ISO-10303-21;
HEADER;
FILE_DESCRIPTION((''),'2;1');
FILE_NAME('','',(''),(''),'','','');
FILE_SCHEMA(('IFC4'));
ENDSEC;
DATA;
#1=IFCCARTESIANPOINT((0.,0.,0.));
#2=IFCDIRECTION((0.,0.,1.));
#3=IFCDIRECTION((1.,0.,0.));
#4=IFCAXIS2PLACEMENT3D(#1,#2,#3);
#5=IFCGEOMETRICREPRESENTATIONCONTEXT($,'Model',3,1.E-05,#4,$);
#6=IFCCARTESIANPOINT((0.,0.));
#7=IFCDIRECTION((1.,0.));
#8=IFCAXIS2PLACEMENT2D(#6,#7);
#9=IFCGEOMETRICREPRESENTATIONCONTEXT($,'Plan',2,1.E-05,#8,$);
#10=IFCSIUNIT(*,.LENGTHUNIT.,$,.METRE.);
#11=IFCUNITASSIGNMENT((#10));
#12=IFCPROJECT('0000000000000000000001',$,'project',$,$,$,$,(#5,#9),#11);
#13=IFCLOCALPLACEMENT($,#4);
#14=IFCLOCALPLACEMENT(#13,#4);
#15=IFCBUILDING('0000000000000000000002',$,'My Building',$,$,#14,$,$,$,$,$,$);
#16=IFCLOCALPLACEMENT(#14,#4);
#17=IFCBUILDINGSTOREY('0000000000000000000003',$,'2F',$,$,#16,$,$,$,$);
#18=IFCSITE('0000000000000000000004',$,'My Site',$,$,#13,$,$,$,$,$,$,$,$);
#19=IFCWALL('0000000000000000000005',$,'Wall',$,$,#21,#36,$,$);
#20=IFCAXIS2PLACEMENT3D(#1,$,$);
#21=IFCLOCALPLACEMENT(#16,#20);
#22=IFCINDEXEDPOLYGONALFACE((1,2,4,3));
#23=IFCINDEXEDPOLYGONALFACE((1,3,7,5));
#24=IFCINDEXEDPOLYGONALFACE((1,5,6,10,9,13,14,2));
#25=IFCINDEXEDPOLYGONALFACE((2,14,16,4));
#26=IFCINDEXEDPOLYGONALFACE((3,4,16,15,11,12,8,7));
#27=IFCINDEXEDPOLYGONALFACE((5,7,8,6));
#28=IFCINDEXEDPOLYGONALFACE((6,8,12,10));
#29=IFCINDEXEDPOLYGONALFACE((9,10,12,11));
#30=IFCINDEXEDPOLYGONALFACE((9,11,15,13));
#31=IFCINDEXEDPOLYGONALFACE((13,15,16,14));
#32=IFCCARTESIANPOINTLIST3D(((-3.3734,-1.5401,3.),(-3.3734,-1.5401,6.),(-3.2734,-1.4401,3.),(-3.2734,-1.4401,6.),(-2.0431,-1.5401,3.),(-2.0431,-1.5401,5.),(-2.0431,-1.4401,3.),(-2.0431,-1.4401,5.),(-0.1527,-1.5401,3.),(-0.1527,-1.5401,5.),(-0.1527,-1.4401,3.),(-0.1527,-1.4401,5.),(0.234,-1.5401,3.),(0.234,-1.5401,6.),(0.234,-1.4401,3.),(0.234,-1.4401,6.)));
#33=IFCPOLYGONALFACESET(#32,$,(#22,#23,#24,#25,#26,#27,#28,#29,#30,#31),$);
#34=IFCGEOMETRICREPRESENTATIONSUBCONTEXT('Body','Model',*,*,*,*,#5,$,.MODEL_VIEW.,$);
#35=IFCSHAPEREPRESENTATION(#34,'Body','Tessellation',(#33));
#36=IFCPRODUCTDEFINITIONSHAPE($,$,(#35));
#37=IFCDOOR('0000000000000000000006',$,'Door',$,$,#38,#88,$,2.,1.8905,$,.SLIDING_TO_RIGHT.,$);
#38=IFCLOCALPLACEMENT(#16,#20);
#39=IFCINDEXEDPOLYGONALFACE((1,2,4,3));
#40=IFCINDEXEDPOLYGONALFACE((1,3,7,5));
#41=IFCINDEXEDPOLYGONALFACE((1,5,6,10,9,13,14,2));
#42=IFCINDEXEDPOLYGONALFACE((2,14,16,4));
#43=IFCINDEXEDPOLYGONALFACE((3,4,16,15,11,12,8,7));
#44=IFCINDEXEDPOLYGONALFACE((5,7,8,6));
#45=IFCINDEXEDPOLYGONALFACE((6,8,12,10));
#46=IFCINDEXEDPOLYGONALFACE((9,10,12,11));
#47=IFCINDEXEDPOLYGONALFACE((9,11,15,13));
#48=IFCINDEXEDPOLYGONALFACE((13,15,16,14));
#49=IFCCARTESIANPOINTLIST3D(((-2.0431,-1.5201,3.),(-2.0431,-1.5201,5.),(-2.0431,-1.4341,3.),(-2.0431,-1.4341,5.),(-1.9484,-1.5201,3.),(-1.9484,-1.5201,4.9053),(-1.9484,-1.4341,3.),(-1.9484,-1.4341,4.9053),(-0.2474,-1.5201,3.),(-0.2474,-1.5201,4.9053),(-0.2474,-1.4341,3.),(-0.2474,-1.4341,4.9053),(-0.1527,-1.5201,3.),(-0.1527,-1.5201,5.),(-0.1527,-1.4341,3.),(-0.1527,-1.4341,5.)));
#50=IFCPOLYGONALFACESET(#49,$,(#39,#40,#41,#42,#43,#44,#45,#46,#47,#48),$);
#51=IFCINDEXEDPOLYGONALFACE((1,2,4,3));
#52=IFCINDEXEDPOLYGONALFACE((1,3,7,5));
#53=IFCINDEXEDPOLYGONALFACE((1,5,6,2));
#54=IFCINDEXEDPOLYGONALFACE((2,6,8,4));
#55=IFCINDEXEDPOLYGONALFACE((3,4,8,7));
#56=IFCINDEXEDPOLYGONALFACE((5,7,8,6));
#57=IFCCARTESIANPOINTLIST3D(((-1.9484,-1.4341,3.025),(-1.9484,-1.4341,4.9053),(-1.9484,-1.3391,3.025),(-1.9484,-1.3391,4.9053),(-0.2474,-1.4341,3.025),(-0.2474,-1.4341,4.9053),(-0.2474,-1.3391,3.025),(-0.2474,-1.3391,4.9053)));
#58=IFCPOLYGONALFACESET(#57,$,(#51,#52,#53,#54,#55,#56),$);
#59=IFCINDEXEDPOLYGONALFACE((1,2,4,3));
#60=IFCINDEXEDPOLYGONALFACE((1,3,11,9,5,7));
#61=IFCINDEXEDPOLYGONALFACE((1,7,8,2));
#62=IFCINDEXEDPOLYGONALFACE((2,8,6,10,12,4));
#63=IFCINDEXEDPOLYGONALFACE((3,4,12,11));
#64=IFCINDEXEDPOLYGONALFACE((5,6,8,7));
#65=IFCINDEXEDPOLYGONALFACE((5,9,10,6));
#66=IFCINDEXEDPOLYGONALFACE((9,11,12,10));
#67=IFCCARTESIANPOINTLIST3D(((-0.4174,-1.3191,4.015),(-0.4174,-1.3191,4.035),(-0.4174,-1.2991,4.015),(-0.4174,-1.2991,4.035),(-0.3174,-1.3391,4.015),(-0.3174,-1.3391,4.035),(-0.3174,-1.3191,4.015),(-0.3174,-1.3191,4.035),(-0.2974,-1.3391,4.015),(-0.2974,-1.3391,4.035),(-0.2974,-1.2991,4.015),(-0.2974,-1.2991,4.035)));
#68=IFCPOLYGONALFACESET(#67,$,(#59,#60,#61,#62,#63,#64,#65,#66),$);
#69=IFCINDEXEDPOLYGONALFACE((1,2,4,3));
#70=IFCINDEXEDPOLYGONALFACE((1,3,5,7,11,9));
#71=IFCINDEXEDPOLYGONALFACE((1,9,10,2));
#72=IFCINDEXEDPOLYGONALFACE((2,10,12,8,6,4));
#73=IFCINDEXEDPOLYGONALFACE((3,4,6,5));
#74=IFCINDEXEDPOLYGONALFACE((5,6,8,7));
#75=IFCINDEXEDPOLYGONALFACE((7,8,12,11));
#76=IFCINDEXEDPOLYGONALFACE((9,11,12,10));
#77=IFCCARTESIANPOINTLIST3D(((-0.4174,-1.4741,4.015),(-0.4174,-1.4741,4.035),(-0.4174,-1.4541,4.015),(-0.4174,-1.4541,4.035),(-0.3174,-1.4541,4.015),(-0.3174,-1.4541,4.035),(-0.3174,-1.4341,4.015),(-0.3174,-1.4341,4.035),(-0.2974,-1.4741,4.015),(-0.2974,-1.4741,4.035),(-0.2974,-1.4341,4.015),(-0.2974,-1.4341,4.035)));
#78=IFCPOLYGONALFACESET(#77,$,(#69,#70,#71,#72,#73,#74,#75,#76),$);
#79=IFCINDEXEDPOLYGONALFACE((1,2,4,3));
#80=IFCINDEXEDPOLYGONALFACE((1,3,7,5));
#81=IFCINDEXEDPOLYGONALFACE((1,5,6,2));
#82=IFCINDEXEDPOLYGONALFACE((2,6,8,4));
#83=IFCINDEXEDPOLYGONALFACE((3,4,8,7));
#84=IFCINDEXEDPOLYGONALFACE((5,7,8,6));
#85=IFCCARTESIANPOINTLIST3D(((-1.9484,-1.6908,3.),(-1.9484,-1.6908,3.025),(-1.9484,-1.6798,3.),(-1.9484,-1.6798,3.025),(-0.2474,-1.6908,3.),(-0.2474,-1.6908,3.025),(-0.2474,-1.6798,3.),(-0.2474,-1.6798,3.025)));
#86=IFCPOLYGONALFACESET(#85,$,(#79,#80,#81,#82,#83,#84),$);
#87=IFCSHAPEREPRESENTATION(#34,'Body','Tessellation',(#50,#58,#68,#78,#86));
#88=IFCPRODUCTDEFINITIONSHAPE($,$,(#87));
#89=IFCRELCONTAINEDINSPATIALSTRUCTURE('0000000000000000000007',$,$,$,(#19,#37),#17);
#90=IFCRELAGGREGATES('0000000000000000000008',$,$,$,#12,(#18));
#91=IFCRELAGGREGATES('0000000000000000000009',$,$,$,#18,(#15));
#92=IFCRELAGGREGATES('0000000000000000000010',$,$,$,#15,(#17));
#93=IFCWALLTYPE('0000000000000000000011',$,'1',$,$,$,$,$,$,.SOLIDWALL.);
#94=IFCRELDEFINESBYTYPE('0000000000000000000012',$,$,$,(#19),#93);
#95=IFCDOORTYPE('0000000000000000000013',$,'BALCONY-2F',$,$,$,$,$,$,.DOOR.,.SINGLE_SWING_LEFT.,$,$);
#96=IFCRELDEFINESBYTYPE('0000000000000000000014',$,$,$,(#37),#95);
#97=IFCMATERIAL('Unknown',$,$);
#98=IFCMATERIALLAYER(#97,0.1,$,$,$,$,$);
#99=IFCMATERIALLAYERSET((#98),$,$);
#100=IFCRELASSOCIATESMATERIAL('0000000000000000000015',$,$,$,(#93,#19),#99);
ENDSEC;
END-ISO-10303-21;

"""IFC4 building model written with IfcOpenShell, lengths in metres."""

from ifc_helpers import new_model, entity, si_unit, frame, origin_with_axes, origin_2d_with_axis, place, context, subcontext, project, spatial, line, indexed_curve, outline, extrude, shape, source, transform, mapped, material, layer, layer_set, layer_usage, type_object, type_shapes, element, fill, save


model = new_model("IFC4")

# Units and contexts
model_context = context("Model", 3, precision=1e-05, world=origin_with_axes())
plan_context = context("Plan", 2, precision=1e-05, world=origin_2d_with_axis())
body_context_1 = subcontext(model_context, "Body", "Model", "MODEL_VIEW")
body_context_2 = subcontext(plan_context, "Body", "Plan", "PLAN_VIEW")
ifc_project = project(units=[si_unit("LENGTHUNIT", "METRE")], contexts=[model_context, plan_context])

# Site, building, storey
site_placement = place(None, origin_with_axes())
site = spatial("IfcSite", under=ifc_project, at=site_placement, Name="My Site")
building_placement = place(site_placement, origin_with_axes())
building = spatial("IfcBuilding", under=site, at=building_placement, Name="My Building")
storey_placement = place(building_placement, origin_with_axes())
storey = spatial("IfcBuildingStorey", under=building, at=storey_placement, Name="2F")

# Shared definitions
ifc_material = material(Name="Unknown")

# Wall, opening, door
ifc_layer_1 = layer(ifc_material, 0.1)
ifc_layer_set_1 = layer_set([ifc_layer_1])
ifc_layer_usage_1 = layer_usage(ifc_layer_set_1, "AXIS2", "POSITIVE", 0.0)
wall_type_1 = type_object("IfcWallType", Name="1", PredefinedType="SOLIDWALL", material=ifc_layer_set_1)
wall_1_placement = place(storey_placement, frame((-3.3734, -1.5401, 3.0), z_axis=(0.0, 0.0, 1.0), x_axis=(1.0, 0.0, 0.0)))
wall_1 = element("IfcWall", 1, at=wall_1_placement, inside=storey, type_object=wall_type_1, material=ifc_layer_usage_1, Name="Wall", context=body_context_1, shape_type="SweptSolid", body=[
    extrude(outline(indexed_curve([(0.0, 0.0), (0.1, 0.1), (3.6074, 0.1), (3.6074, 0.0)], segments=[line(1, 2, 3, 4, 1)])), origin_with_axes(), (0.0, 0.0, 1.0), 3.0),
])
shared_shape_1 = source(origin_with_axes(), body_context_1, "Body", "SweptSolid", [
    extrude(outline(indexed_curve([(0.0, 0.0), (1.8905, 0.0), (1.8905, 2.0), (0.0, 2.0)], segments=[line(1, 2, 3, 4, 1)])), frame((0.0, -0.6, 0.0), z_axis=(0.0, -1.0, 0.0), x_axis=(1.0, 0.0, 0.0)), (0.0, 0.0, -1.0), 1.2),
])
opening_1_placement = place(wall_1_placement, frame((1.3303, 0.0, 0.0), z_axis=(0.0, 0.0, 1.0), x_axis=(1.0, 0.0, 0.0)))
opening_1 = element("IfcOpeningElement", 2, at=opening_1_placement, cuts=wall_1, PredefinedType="OPENING", context=body_context_1, shape_type="MappedRepresentation", body=[
    mapped(shared_shape_1, transform((0.0, 0.0, 0.0), x_axis=(1.0, 0.0, 0.0), y_axis=(0.0, 1.0, 0.0), z_axis=(0.0, 0.0, 1.0), scale=1.0)),
])
door_type_1 = type_object("IfcDoorType", Name="BALCONY-2F", OperationType="SINGLE_SWING_LEFT", PredefinedType="DOOR")
shared_shape_2 = source(origin_with_axes(), body_context_1, "Body", "SweptSolid", [
    extrude(outline(indexed_curve([(0.0, 0.0), (0.0, 2.0), (1.8905, 2.0), (1.8905, 0.0), (1.7957, 0.0), (1.7957, 1.9053), (0.0947, 1.9053), (0.0947, 0.0)], segments=[line(1, 2, 3, 4, 5, 6, 7, 8, 1)])), frame((0.0, -0.0157, 0.0), z_axis=(0.0, -1.0, 0.0), x_axis=(1.0, 0.0, 0.0)), (0.0, 0.0, -1.0), 0.086),
    extrude(outline(indexed_curve([(0.0, 0.0), (1.701, 0.0), (1.701, 0.095), (0.0, 0.095)], segments=[line(1, 2, 3, 4, 1)])), frame((0.0947, -0.1107, 0.025), z_axis=(0.0, 0.0, 1.0), x_axis=(1.0, 0.0, 0.0)), (0.0, 0.0, 1.0), 1.8803),
    extrude(outline(indexed_curve([(0.0, 0.0), (0.0, -0.04), (0.12, -0.04), (0.12, -0.02), (0.02, -0.02), (0.02, 0.0)], segments=[line(1, 2, 3, 4, 5, 6, 1)])), frame((0.1447, -0.1107, 1.015), z_axis=(0.0, 0.0, 1.0), x_axis=(1.0, 0.0, 0.0)), (0.0, 0.0, 1.0), 0.02),
    extrude(outline(indexed_curve([(0.0, 0.0), (0.0, 0.04), (0.12, 0.04), (0.12, 0.02), (0.02, 0.02), (0.02, 0.0)], segments=[line(1, 2, 3, 4, 5, 6, 1)])), frame((0.1447, -0.0157, 1.015), z_axis=(0.0, 0.0, 1.0), x_axis=(1.0, 0.0, 0.0)), (0.0, 0.0, 1.0), 0.02),
    extrude(outline(indexed_curve([(0.0, 0.0), (1.701, 0.0), (1.701, 0.011), (0.0, 0.011)], segments=[line(1, 2, 3, 4, 1)])), frame((0.0947, 0.23, 0.0), z_axis=(0.0, 0.0, 1.0), x_axis=(1.0, 0.0, 0.0)), (0.0, 0.0, 1.0), 0.025),
])
shared_shape_3 = source(origin_with_axes(), body_context_2, "Body", "Curve2D", [
    entity("IfcIndexedPolyCurve", entity("IfcCartesianPointList2D", [[0.0, -0.0157], [0.0947, -0.0157], [0.0947, 0.0703], [0.0, 0.0703]]), [entity("IfcLineIndex", [1, 2, 3, 4, 1])]),
    entity("IfcIndexedPolyCurve", entity("IfcCartesianPointList2D", [[1.8905, -0.0157], [1.7957, -0.0157], [1.7957, 0.0703], [1.8905, 0.0703]]), [entity("IfcLineIndex", [1, 2, 3, 4, 1])]),
    entity("IfcIndexedPolyCurve", entity("IfcCartesianPointList2D", [[2.6462, -0.1107], [0.9452, -0.1107], [0.9452, -0.0157], [2.6462, -0.0157]]), [entity("IfcLineIndex", [1, 2, 3, 4, 1])]),
])
type_shapes(door_type_1, [shared_shape_2, shared_shape_3])
door_1_placement = place(opening_1_placement, frame((1.8905, 0.0903, 0.0), z_axis=(0.0, 0.0, 1.0), x_axis=(-1.0, 0.0, 0.0)))
door_1 = element("IfcDoor", 3, at=door_1_placement, inside=storey, type_object=door_type_1, Name="Door", OperationType="SLIDING_TO_RIGHT", OverallHeight=2.0, OverallWidth=1.8905, shapes=[
    shape(body_context_1, "Body", "MappedRepresentation", [mapped(shared_shape_2, transform((0.0, 0.0, 0.0), x_axis=(1.0, 0.0, 0.0), y_axis=(0.0, 1.0, 0.0), z_axis=(0.0, 0.0, 1.0), scale=1.0))]),
    shape(body_context_2, "Body", "MappedRepresentation", [mapped(shared_shape_3, transform((0.0, 0.0, 0.0), x_axis=(1.0, 0.0, 0.0), y_axis=(0.0, 1.0, 0.0), z_axis=(0.0, 0.0, 1.0), scale=1.0))]),
])
fill(opening_1, door_1)

save(model, "model.ifc")
